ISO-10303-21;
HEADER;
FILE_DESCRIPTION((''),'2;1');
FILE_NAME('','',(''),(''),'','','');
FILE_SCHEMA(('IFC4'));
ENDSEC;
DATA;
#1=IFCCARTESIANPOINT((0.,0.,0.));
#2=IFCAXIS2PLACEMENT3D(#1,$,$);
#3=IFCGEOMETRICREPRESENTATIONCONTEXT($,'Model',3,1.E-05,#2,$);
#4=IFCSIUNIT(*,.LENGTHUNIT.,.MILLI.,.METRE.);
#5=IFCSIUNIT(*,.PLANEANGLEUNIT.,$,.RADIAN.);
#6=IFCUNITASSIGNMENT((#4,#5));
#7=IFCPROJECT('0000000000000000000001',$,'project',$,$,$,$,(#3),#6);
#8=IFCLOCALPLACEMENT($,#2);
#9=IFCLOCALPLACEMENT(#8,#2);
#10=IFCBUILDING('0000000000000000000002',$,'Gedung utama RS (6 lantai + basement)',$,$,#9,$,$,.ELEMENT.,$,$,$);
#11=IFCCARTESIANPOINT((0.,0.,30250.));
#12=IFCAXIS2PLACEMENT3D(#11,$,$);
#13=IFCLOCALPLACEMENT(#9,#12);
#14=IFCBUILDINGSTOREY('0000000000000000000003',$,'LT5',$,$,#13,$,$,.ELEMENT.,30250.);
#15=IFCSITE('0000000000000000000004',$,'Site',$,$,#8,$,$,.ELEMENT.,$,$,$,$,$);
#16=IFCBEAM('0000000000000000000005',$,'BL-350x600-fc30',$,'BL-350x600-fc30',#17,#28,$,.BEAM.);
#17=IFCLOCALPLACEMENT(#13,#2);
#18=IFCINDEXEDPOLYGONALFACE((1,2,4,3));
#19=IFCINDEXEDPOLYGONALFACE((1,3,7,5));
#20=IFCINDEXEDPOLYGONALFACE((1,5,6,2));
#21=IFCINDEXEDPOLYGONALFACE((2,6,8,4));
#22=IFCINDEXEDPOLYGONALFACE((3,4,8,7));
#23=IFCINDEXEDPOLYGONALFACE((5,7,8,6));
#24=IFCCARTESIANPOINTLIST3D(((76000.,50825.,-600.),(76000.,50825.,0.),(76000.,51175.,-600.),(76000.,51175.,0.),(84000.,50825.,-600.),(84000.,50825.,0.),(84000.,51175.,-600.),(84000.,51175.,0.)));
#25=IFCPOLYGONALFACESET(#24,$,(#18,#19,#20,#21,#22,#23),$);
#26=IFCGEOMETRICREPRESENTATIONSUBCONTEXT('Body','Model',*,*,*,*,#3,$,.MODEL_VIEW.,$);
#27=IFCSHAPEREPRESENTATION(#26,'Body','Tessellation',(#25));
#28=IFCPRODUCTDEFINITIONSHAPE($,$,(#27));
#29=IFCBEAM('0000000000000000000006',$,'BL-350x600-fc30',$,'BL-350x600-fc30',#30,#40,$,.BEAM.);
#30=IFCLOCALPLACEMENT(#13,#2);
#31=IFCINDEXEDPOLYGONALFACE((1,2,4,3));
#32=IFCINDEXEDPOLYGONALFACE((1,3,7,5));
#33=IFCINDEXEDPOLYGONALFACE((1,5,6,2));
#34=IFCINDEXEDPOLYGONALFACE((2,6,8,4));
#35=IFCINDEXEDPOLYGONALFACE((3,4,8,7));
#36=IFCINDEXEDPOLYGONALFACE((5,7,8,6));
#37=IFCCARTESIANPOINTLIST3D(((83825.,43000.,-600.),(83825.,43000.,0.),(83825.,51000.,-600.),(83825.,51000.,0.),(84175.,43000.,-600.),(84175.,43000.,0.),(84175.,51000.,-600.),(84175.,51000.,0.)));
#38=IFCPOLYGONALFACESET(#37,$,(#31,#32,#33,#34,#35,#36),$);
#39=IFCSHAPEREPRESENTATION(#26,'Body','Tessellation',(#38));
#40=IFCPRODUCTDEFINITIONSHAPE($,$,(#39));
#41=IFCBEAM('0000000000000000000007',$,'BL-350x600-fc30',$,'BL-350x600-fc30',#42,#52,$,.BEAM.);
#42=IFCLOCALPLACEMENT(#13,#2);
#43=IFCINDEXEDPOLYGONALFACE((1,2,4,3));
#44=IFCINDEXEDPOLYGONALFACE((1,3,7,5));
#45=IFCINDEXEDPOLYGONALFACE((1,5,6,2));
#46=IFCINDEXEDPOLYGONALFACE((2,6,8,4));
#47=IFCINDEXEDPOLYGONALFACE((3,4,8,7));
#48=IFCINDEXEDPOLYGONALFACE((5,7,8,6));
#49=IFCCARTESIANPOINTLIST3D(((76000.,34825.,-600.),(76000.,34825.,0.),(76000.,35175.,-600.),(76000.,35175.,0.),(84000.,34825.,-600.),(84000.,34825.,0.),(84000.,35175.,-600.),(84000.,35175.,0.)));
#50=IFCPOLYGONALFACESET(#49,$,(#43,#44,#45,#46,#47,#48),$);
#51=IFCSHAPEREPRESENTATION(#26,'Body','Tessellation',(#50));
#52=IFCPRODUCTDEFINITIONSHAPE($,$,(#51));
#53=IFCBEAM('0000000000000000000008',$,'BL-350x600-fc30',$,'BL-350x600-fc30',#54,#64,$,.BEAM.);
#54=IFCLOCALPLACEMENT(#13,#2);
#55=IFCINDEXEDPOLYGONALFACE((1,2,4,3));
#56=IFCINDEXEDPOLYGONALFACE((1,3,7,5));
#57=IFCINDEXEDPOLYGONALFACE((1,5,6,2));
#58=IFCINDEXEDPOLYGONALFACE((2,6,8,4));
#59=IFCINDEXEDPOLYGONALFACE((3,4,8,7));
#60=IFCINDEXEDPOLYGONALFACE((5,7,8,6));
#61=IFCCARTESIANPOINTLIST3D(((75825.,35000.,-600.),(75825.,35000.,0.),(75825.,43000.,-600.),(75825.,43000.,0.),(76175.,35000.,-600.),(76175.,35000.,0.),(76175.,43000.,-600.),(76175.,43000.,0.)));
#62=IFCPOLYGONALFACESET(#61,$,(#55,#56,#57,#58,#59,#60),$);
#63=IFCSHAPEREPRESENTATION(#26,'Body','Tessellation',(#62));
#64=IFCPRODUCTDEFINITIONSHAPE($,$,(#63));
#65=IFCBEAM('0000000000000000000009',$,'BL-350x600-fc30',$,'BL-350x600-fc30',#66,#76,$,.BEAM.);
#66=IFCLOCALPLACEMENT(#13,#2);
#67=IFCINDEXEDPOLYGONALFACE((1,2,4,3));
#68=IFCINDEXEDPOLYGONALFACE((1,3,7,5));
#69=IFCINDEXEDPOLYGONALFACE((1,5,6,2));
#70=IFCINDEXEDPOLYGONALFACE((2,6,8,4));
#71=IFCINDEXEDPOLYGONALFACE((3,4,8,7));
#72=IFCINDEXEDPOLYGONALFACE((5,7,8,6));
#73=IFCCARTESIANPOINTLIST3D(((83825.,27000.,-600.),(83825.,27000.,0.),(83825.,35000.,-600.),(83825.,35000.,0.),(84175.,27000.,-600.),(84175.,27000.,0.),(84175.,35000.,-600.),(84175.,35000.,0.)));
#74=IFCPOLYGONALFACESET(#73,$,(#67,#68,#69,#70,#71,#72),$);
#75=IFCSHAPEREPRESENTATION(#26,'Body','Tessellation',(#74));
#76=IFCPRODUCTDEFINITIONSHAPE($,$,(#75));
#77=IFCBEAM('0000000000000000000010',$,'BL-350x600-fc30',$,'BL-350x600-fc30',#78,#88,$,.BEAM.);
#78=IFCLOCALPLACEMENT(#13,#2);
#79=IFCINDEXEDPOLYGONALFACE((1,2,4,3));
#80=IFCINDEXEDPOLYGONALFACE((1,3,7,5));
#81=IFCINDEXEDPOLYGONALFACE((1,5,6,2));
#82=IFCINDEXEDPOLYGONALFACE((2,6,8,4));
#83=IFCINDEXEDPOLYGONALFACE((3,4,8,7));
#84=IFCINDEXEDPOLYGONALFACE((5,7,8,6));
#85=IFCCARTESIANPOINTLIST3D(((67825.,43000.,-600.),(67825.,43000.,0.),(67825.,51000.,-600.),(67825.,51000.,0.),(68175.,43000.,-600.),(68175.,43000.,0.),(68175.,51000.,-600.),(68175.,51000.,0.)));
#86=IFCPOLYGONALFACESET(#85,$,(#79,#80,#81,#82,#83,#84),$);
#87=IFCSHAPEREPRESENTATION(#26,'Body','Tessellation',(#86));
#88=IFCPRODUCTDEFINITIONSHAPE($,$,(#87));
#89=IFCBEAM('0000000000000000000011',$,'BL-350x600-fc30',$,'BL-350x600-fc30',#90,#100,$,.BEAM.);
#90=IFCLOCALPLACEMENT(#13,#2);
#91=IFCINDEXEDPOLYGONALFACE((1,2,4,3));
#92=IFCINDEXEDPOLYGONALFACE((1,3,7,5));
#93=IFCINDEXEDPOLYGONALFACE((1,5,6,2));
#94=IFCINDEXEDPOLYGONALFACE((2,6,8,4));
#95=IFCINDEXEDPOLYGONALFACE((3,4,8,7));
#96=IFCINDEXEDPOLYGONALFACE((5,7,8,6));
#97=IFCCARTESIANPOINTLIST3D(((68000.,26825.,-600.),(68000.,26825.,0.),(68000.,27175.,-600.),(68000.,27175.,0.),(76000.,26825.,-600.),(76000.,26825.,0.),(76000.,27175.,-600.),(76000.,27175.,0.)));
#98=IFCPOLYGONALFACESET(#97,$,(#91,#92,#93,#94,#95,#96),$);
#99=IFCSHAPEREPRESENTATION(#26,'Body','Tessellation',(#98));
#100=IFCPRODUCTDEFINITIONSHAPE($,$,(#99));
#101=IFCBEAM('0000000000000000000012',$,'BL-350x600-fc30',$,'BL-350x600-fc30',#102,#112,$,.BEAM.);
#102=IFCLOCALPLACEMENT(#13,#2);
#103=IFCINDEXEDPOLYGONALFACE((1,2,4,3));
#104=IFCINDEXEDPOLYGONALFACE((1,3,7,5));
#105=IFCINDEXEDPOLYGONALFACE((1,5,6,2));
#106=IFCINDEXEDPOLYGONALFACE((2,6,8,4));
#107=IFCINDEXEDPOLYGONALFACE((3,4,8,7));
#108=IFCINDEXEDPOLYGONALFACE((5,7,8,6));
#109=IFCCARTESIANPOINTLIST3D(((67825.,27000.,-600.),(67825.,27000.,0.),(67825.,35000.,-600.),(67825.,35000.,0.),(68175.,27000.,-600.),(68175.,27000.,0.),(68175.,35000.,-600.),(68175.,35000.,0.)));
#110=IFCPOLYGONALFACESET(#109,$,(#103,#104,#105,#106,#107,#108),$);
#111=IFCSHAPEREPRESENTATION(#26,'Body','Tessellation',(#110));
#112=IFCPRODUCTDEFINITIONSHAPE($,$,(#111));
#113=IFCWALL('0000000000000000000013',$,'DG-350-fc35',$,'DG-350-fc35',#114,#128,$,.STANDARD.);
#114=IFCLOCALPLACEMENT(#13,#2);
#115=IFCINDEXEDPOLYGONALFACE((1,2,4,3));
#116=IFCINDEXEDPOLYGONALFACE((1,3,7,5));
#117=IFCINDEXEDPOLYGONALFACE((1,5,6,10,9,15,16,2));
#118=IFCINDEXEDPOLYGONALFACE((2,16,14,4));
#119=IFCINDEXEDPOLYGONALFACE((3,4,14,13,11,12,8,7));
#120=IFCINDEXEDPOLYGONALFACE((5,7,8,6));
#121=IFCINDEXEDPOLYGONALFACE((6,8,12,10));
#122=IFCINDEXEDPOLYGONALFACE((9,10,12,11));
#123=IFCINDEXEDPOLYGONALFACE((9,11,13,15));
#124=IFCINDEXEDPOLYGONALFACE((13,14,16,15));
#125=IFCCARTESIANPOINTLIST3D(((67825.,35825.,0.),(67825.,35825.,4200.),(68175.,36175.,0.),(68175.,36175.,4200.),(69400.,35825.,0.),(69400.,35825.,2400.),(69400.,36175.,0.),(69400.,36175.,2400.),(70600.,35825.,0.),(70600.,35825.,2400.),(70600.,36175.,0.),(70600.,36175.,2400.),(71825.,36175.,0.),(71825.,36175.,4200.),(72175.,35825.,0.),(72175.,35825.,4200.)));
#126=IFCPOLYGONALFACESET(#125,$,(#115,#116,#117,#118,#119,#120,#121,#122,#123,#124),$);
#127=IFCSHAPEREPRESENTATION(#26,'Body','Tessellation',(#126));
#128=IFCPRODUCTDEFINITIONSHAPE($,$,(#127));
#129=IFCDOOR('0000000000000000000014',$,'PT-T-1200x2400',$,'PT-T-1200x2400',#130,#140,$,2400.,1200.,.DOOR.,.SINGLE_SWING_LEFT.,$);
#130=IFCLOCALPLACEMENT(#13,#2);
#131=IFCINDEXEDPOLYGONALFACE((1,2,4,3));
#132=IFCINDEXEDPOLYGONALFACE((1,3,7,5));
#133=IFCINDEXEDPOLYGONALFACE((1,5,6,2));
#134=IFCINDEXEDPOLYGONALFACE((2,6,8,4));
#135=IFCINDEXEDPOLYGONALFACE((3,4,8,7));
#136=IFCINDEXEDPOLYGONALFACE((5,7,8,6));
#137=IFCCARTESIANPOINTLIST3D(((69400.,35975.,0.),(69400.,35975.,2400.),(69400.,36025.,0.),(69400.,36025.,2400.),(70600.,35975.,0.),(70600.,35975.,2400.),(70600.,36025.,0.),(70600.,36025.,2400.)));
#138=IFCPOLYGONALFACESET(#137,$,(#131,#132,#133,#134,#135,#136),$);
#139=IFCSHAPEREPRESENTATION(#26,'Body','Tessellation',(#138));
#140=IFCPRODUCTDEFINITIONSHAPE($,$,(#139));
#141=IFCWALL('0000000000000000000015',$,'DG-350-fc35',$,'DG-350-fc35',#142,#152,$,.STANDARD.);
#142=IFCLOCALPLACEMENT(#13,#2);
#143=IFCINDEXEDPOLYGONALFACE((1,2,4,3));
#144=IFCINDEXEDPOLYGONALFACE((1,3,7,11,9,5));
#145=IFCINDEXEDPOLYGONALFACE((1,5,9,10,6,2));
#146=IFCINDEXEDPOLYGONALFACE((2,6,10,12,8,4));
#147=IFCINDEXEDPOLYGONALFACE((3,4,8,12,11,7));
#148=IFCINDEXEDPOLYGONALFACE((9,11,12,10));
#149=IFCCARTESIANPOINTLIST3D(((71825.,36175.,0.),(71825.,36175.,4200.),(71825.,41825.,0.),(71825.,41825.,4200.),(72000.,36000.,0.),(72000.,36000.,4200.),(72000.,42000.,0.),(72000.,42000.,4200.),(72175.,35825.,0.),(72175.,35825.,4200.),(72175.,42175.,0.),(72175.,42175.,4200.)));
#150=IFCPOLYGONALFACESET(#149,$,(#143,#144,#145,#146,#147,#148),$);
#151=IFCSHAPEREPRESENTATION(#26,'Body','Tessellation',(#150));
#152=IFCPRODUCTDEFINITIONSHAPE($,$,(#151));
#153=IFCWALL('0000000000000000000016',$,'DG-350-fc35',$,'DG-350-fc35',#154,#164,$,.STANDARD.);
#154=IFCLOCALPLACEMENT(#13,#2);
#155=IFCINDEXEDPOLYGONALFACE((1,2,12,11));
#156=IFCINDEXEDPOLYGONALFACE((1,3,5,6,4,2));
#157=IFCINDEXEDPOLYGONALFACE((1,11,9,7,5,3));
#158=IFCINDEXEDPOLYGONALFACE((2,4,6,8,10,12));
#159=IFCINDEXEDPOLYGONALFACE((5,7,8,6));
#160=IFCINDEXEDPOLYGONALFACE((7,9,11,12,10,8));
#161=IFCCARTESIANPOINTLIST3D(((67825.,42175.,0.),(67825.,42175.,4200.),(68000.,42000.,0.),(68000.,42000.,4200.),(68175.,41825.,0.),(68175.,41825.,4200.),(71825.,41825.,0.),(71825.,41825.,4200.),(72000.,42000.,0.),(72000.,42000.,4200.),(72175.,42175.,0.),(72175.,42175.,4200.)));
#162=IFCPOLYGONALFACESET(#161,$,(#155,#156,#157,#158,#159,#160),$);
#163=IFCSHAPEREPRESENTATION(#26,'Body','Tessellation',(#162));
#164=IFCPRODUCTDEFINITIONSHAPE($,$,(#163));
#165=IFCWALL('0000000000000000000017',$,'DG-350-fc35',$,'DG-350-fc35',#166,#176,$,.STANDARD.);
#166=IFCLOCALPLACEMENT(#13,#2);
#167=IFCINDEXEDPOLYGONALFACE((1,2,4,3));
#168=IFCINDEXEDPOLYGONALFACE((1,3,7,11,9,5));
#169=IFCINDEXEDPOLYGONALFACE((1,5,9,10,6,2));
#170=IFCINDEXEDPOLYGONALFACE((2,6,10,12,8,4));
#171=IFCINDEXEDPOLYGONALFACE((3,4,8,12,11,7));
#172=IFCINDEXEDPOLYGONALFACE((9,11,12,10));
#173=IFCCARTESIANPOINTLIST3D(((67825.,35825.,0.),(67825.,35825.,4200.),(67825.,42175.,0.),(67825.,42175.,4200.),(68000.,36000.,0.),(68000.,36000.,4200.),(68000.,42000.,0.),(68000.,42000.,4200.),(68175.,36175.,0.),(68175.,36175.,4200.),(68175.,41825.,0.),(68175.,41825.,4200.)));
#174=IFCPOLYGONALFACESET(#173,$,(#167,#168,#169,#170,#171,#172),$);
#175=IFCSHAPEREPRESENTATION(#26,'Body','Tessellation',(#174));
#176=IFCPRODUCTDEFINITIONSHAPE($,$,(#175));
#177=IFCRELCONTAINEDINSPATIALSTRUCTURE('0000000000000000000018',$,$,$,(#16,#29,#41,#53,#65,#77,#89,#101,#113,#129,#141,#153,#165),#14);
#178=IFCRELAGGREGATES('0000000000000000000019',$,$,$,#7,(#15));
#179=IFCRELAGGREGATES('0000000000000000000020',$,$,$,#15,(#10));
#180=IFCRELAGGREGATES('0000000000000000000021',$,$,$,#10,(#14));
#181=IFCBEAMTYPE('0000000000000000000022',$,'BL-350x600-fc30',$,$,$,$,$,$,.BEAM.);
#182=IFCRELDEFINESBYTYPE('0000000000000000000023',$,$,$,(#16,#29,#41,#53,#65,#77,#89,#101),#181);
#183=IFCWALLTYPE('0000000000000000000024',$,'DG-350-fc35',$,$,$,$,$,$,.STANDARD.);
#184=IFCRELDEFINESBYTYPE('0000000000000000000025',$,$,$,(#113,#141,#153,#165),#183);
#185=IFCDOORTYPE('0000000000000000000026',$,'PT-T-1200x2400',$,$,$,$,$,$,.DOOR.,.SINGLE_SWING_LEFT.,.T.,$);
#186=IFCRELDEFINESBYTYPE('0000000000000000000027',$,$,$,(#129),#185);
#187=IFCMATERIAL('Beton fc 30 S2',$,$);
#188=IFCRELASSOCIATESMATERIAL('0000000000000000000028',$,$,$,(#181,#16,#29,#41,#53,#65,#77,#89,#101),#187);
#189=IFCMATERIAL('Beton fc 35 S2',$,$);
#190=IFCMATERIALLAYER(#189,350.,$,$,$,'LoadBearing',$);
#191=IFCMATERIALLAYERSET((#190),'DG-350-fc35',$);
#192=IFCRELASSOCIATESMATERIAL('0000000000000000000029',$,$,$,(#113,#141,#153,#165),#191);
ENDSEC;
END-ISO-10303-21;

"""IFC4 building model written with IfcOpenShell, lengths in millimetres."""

from ifc_helpers import new_model, si_unit, frame, frame_2d, origin, origin_2d, place, context, subcontext, project, spatial, polyline, rectangle, outline, extrude, material, layer, layer_set, layer_usage, material_profile, profile_set, profile_usage, type_object, element, fill, save


model = new_model("IFC4")

# Units and contexts
model_context = context("Model", 3, precision=1e-05, world=origin())
body_context = subcontext(model_context, "Body", "Model", "MODEL_VIEW")
ifc_project = project(units=[si_unit("LENGTHUNIT", "METRE", prefix="MILLI"), si_unit("PLANEANGLEUNIT", "RADIAN")], contexts=[model_context])

# Site, building, storey
site_placement = place(None, origin())
site = spatial("IfcSite", under=ifc_project, at=site_placement, Name="Site", CompositionType="ELEMENT")
building_placement = place(site_placement, origin())
building = spatial("IfcBuilding", under=site, at=building_placement, Name="Gedung utama RS (6 lantai + basement)", CompositionType="ELEMENT")
storey_placement = place(building_placement, frame((0.0, 0.0, 30250.0)))
storey = spatial("IfcBuildingStorey", under=building, at=storey_placement, Name="LT5", CompositionType="ELEMENT", Elevation=30250.0)

# Beams
ifc_material_1 = material(Name="Beton fc 30 S2")
ifc_material_profile_1 = material_profile(ifc_material_1, rectangle(XDim=350.0, YDim=600.0, at=origin_2d()), Name="BL-350x600-fc30")
ifc_profile_set_1 = profile_set([ifc_material_profile_1], Name="BL-350x600-fc30")
ifc_profile_usage_1 = profile_usage(ifc_profile_set_1, cardinal=8)
beam_type = type_object("IfcBeamType", Name="BL-350x600-fc30", PredefinedType="BEAM", material=ifc_profile_set_1)
beam_1_placement = place(storey_placement, frame((76000.0, 51000.0, -300.0)))
element("IfcBeam", 1, at=beam_1_placement, inside=storey, type_object=beam_type, material=ifc_profile_usage_1, Name="BL-350x600-fc30", ObjectType="BL-350x600-fc30", PredefinedType="BEAM", context=body_context, shape_type="SweptSolid", body=[
    extrude(rectangle(XDim=350.0, YDim=600.0, at=origin_2d()), frame((0.0, 0.0, 0.0), z_axis=(1.0, 0.0, 0.0), x_axis=(0.0, 1.0, 0.0)), (0.0, 0.0, 1.0), 8000.0),
])
beam_2_placement = place(storey_placement, frame((84000.0, 43000.0, -300.0)))
element("IfcBeam", 2, at=beam_2_placement, inside=storey, type_object=beam_type, material=ifc_profile_usage_1, Name="BL-350x600-fc30", ObjectType="BL-350x600-fc30", PredefinedType="BEAM", context=body_context, shape_type="SweptSolid", body=[
    extrude(rectangle(XDim=350.0, YDim=600.0, at=origin_2d()), frame((0.0, 0.0, 0.0), z_axis=(0.0, 1.0, 0.0), x_axis=(-1.0, 0.0, 0.0)), (0.0, 0.0, 1.0), 8000.0),
])
beam_3_placement = place(storey_placement, frame((76000.0, 35000.0, -300.0)))
element("IfcBeam", 3, at=beam_3_placement, inside=storey, type_object=beam_type, material=ifc_profile_usage_1, Name="BL-350x600-fc30", ObjectType="BL-350x600-fc30", PredefinedType="BEAM", context=body_context, shape_type="SweptSolid", body=[
    extrude(rectangle(XDim=350.0, YDim=600.0, at=origin_2d()), frame((0.0, 0.0, 0.0), z_axis=(1.0, 0.0, 0.0), x_axis=(0.0, 1.0, 0.0)), (0.0, 0.0, 1.0), 8000.0),
])
for number, where, name in (
    (4, (76000.0, 35000.0, -300.0), "BL-350x600-fc30"),
    (5, (84000.0, 27000.0, -300.0), "BL-350x600-fc30"),
    (6, (68000.0, 43000.0, -300.0), "BL-350x600-fc30"),
):
    element("IfcBeam", number, at=place(storey_placement, frame(where)), inside=storey, type_object=beam_type, material=ifc_profile_usage_1, Name=name, ObjectType="BL-350x600-fc30", PredefinedType="BEAM", context=body_context, shape_type="SweptSolid", body=[
        extrude(rectangle(XDim=350.0, YDim=600.0, at=origin_2d()), frame((0.0, 0.0, 0.0), z_axis=(0.0, 1.0, 0.0), x_axis=(-1.0, 0.0, 0.0)), (0.0, 0.0, 1.0), 8000.0),
    ])
beam_4_placement = place(storey_placement, frame((68000.0, 27000.0, -300.0)))
element("IfcBeam", 7, at=beam_4_placement, inside=storey, type_object=beam_type, material=ifc_profile_usage_1, Name="BL-350x600-fc30", ObjectType="BL-350x600-fc30", PredefinedType="BEAM", context=body_context, shape_type="SweptSolid", body=[
    extrude(rectangle(XDim=350.0, YDim=600.0, at=origin_2d()), frame((0.0, 0.0, 0.0), z_axis=(1.0, 0.0, 0.0), x_axis=(0.0, 1.0, 0.0)), (0.0, 0.0, 1.0), 8000.0),
])
beam_5_placement = place(storey_placement, frame((68000.0, 27000.0, -300.0)))
element("IfcBeam", 8, at=beam_5_placement, inside=storey, type_object=beam_type, material=ifc_profile_usage_1, Name="BL-350x600-fc30", ObjectType="BL-350x600-fc30", PredefinedType="BEAM", context=body_context, shape_type="SweptSolid", body=[
    extrude(rectangle(XDim=350.0, YDim=600.0, at=origin_2d()), frame((0.0, 0.0, 0.0), z_axis=(0.0, 1.0, 0.0), x_axis=(-1.0, 0.0, 0.0)), (0.0, 0.0, 1.0), 8000.0),
])

# Wall, opening, door
ifc_material_2 = material(Name="Beton fc 35 S2")
ifc_layer_1 = layer(ifc_material_2, 350.0, Category="LoadBearing")
ifc_layer_set_1 = layer_set([ifc_layer_1], Name="DG-350-fc35")
ifc_layer_usage_1 = layer_usage(ifc_layer_set_1, "AXIS2", "NEGATIVE", 175.0)
wall_type_1 = type_object("IfcWallType", Name="DG-350-fc35", PredefinedType="STANDARD")
wall_1_placement = place(storey_placement, frame((68000.0, 36000.0, 0.0), z_axis=(0.0, 0.0, 1.0), x_axis=(1.0, 0.0, 0.0)))
wall_1 = element("IfcWall", 9, at=wall_1_placement, inside=storey, type_object=wall_type_1, material=ifc_layer_usage_1, Name="DG-350-fc35", ObjectType="DG-350-fc35", PredefinedType="STANDARD", context=body_context, shape_type="SweptSolid", body=[
    extrude(outline(polyline([(-175.0, -175.0), (0.0, 0.0), (175.0, 175.0), (3825.0, 175.0), (4000.0, 0.0), (4175.0, -175.0), (-175.0, -175.0)])), origin(), (0.0, 0.0, 1.0), 4200.0),
])
opening_placement = place(wall_1_placement, frame((1400.0, 0.0, 0.0), z_axis=(0.0, 0.0, 1.0), x_axis=(1.0, 0.0, 0.0)))
opening = element("IfcOpeningElement", 10, at=opening_placement, cuts=wall_1, PredefinedType="OPENING", context=body_context, shape_type="SweptSolid", body=[
    extrude(rectangle(XDim=1200.0, YDim=370.0, at=frame_2d((600.0, 0.0))), origin(), (0.0, 0.0, 1.0), 2400.0),
])
door_type = type_object("IfcDoorType", Name="PT-T-1200x2400", OperationType="SINGLE_SWING_LEFT", ParameterTakesPrecedence=True, PredefinedType="DOOR")
door_placement = place(opening_placement, origin())
door = element("IfcDoor", 11, at=door_placement, inside=storey, type_object=door_type, Name="PT-T-1200x2400", ObjectType="PT-T-1200x2400", OperationType="SINGLE_SWING_LEFT", OverallHeight=2400.0, OverallWidth=1200.0, PredefinedType="DOOR", context=body_context, shape_type="SweptSolid", body=[
    extrude(rectangle(XDim=1200.0, YDim=50.0, at=frame_2d((600.0, 0.0))), origin(), (0.0, 0.0, 1.0), 2400.0),
])
fill(opening, door)

# Walls
wall_2_placement = place(storey_placement, frame((72000.0, 36000.0, 0.0), z_axis=(0.0, 0.0, 1.0), x_axis=(0.0, 1.0, 0.0)))
element("IfcWall", 12, at=wall_2_placement, inside=storey, type_object=wall_type_1, material=ifc_layer_usage_1, Name="DG-350-fc35", ObjectType="DG-350-fc35", PredefinedType="STANDARD", context=body_context, shape_type="SweptSolid", body=[
    extrude(outline(polyline([(-175.0, -175.0), (0.0, 0.0), (175.0, 175.0), (5825.0, 175.0), (6000.0, 0.0), (6175.0, -175.0), (-175.0, -175.0)])), origin(), (0.0, 0.0, 1.0), 4200.0),
])
wall_3_placement = place(storey_placement, frame((72000.0, 42000.0, 0.0), z_axis=(0.0, 0.0, 1.0), x_axis=(-1.0, 0.0, 0.0)))
element("IfcWall", 13, at=wall_3_placement, inside=storey, type_object=wall_type_1, material=ifc_layer_usage_1, Name="DG-350-fc35", ObjectType="DG-350-fc35", PredefinedType="STANDARD", context=body_context, shape_type="SweptSolid", body=[
    extrude(outline(polyline([(-175.0, -175.0), (0.0, 0.0), (175.0, 175.0), (3825.0, 175.0), (4000.0, 0.0), (4175.0, -175.0), (-175.0, -175.0)])), origin(), (0.0, 0.0, 1.0), 4200.0),
])
wall_4_placement = place(storey_placement, frame((68000.0, 42000.0, 0.0), z_axis=(0.0, 0.0, 1.0), x_axis=(0.0, -1.0, 0.0)))
element("IfcWall", 14, at=wall_4_placement, inside=storey, type_object=wall_type_1, material=ifc_layer_usage_1, Name="DG-350-fc35", ObjectType="DG-350-fc35", PredefinedType="STANDARD", context=body_context, shape_type="SweptSolid", body=[
    extrude(outline(polyline([(-175.0, -175.0), (0.0, 0.0), (175.0, 175.0), (5825.0, 175.0), (6000.0, 0.0), (6175.0, -175.0), (-175.0, -175.0)])), origin(), (0.0, 0.0, 1.0), 4200.0),
])

save(model, "model.ifc")
